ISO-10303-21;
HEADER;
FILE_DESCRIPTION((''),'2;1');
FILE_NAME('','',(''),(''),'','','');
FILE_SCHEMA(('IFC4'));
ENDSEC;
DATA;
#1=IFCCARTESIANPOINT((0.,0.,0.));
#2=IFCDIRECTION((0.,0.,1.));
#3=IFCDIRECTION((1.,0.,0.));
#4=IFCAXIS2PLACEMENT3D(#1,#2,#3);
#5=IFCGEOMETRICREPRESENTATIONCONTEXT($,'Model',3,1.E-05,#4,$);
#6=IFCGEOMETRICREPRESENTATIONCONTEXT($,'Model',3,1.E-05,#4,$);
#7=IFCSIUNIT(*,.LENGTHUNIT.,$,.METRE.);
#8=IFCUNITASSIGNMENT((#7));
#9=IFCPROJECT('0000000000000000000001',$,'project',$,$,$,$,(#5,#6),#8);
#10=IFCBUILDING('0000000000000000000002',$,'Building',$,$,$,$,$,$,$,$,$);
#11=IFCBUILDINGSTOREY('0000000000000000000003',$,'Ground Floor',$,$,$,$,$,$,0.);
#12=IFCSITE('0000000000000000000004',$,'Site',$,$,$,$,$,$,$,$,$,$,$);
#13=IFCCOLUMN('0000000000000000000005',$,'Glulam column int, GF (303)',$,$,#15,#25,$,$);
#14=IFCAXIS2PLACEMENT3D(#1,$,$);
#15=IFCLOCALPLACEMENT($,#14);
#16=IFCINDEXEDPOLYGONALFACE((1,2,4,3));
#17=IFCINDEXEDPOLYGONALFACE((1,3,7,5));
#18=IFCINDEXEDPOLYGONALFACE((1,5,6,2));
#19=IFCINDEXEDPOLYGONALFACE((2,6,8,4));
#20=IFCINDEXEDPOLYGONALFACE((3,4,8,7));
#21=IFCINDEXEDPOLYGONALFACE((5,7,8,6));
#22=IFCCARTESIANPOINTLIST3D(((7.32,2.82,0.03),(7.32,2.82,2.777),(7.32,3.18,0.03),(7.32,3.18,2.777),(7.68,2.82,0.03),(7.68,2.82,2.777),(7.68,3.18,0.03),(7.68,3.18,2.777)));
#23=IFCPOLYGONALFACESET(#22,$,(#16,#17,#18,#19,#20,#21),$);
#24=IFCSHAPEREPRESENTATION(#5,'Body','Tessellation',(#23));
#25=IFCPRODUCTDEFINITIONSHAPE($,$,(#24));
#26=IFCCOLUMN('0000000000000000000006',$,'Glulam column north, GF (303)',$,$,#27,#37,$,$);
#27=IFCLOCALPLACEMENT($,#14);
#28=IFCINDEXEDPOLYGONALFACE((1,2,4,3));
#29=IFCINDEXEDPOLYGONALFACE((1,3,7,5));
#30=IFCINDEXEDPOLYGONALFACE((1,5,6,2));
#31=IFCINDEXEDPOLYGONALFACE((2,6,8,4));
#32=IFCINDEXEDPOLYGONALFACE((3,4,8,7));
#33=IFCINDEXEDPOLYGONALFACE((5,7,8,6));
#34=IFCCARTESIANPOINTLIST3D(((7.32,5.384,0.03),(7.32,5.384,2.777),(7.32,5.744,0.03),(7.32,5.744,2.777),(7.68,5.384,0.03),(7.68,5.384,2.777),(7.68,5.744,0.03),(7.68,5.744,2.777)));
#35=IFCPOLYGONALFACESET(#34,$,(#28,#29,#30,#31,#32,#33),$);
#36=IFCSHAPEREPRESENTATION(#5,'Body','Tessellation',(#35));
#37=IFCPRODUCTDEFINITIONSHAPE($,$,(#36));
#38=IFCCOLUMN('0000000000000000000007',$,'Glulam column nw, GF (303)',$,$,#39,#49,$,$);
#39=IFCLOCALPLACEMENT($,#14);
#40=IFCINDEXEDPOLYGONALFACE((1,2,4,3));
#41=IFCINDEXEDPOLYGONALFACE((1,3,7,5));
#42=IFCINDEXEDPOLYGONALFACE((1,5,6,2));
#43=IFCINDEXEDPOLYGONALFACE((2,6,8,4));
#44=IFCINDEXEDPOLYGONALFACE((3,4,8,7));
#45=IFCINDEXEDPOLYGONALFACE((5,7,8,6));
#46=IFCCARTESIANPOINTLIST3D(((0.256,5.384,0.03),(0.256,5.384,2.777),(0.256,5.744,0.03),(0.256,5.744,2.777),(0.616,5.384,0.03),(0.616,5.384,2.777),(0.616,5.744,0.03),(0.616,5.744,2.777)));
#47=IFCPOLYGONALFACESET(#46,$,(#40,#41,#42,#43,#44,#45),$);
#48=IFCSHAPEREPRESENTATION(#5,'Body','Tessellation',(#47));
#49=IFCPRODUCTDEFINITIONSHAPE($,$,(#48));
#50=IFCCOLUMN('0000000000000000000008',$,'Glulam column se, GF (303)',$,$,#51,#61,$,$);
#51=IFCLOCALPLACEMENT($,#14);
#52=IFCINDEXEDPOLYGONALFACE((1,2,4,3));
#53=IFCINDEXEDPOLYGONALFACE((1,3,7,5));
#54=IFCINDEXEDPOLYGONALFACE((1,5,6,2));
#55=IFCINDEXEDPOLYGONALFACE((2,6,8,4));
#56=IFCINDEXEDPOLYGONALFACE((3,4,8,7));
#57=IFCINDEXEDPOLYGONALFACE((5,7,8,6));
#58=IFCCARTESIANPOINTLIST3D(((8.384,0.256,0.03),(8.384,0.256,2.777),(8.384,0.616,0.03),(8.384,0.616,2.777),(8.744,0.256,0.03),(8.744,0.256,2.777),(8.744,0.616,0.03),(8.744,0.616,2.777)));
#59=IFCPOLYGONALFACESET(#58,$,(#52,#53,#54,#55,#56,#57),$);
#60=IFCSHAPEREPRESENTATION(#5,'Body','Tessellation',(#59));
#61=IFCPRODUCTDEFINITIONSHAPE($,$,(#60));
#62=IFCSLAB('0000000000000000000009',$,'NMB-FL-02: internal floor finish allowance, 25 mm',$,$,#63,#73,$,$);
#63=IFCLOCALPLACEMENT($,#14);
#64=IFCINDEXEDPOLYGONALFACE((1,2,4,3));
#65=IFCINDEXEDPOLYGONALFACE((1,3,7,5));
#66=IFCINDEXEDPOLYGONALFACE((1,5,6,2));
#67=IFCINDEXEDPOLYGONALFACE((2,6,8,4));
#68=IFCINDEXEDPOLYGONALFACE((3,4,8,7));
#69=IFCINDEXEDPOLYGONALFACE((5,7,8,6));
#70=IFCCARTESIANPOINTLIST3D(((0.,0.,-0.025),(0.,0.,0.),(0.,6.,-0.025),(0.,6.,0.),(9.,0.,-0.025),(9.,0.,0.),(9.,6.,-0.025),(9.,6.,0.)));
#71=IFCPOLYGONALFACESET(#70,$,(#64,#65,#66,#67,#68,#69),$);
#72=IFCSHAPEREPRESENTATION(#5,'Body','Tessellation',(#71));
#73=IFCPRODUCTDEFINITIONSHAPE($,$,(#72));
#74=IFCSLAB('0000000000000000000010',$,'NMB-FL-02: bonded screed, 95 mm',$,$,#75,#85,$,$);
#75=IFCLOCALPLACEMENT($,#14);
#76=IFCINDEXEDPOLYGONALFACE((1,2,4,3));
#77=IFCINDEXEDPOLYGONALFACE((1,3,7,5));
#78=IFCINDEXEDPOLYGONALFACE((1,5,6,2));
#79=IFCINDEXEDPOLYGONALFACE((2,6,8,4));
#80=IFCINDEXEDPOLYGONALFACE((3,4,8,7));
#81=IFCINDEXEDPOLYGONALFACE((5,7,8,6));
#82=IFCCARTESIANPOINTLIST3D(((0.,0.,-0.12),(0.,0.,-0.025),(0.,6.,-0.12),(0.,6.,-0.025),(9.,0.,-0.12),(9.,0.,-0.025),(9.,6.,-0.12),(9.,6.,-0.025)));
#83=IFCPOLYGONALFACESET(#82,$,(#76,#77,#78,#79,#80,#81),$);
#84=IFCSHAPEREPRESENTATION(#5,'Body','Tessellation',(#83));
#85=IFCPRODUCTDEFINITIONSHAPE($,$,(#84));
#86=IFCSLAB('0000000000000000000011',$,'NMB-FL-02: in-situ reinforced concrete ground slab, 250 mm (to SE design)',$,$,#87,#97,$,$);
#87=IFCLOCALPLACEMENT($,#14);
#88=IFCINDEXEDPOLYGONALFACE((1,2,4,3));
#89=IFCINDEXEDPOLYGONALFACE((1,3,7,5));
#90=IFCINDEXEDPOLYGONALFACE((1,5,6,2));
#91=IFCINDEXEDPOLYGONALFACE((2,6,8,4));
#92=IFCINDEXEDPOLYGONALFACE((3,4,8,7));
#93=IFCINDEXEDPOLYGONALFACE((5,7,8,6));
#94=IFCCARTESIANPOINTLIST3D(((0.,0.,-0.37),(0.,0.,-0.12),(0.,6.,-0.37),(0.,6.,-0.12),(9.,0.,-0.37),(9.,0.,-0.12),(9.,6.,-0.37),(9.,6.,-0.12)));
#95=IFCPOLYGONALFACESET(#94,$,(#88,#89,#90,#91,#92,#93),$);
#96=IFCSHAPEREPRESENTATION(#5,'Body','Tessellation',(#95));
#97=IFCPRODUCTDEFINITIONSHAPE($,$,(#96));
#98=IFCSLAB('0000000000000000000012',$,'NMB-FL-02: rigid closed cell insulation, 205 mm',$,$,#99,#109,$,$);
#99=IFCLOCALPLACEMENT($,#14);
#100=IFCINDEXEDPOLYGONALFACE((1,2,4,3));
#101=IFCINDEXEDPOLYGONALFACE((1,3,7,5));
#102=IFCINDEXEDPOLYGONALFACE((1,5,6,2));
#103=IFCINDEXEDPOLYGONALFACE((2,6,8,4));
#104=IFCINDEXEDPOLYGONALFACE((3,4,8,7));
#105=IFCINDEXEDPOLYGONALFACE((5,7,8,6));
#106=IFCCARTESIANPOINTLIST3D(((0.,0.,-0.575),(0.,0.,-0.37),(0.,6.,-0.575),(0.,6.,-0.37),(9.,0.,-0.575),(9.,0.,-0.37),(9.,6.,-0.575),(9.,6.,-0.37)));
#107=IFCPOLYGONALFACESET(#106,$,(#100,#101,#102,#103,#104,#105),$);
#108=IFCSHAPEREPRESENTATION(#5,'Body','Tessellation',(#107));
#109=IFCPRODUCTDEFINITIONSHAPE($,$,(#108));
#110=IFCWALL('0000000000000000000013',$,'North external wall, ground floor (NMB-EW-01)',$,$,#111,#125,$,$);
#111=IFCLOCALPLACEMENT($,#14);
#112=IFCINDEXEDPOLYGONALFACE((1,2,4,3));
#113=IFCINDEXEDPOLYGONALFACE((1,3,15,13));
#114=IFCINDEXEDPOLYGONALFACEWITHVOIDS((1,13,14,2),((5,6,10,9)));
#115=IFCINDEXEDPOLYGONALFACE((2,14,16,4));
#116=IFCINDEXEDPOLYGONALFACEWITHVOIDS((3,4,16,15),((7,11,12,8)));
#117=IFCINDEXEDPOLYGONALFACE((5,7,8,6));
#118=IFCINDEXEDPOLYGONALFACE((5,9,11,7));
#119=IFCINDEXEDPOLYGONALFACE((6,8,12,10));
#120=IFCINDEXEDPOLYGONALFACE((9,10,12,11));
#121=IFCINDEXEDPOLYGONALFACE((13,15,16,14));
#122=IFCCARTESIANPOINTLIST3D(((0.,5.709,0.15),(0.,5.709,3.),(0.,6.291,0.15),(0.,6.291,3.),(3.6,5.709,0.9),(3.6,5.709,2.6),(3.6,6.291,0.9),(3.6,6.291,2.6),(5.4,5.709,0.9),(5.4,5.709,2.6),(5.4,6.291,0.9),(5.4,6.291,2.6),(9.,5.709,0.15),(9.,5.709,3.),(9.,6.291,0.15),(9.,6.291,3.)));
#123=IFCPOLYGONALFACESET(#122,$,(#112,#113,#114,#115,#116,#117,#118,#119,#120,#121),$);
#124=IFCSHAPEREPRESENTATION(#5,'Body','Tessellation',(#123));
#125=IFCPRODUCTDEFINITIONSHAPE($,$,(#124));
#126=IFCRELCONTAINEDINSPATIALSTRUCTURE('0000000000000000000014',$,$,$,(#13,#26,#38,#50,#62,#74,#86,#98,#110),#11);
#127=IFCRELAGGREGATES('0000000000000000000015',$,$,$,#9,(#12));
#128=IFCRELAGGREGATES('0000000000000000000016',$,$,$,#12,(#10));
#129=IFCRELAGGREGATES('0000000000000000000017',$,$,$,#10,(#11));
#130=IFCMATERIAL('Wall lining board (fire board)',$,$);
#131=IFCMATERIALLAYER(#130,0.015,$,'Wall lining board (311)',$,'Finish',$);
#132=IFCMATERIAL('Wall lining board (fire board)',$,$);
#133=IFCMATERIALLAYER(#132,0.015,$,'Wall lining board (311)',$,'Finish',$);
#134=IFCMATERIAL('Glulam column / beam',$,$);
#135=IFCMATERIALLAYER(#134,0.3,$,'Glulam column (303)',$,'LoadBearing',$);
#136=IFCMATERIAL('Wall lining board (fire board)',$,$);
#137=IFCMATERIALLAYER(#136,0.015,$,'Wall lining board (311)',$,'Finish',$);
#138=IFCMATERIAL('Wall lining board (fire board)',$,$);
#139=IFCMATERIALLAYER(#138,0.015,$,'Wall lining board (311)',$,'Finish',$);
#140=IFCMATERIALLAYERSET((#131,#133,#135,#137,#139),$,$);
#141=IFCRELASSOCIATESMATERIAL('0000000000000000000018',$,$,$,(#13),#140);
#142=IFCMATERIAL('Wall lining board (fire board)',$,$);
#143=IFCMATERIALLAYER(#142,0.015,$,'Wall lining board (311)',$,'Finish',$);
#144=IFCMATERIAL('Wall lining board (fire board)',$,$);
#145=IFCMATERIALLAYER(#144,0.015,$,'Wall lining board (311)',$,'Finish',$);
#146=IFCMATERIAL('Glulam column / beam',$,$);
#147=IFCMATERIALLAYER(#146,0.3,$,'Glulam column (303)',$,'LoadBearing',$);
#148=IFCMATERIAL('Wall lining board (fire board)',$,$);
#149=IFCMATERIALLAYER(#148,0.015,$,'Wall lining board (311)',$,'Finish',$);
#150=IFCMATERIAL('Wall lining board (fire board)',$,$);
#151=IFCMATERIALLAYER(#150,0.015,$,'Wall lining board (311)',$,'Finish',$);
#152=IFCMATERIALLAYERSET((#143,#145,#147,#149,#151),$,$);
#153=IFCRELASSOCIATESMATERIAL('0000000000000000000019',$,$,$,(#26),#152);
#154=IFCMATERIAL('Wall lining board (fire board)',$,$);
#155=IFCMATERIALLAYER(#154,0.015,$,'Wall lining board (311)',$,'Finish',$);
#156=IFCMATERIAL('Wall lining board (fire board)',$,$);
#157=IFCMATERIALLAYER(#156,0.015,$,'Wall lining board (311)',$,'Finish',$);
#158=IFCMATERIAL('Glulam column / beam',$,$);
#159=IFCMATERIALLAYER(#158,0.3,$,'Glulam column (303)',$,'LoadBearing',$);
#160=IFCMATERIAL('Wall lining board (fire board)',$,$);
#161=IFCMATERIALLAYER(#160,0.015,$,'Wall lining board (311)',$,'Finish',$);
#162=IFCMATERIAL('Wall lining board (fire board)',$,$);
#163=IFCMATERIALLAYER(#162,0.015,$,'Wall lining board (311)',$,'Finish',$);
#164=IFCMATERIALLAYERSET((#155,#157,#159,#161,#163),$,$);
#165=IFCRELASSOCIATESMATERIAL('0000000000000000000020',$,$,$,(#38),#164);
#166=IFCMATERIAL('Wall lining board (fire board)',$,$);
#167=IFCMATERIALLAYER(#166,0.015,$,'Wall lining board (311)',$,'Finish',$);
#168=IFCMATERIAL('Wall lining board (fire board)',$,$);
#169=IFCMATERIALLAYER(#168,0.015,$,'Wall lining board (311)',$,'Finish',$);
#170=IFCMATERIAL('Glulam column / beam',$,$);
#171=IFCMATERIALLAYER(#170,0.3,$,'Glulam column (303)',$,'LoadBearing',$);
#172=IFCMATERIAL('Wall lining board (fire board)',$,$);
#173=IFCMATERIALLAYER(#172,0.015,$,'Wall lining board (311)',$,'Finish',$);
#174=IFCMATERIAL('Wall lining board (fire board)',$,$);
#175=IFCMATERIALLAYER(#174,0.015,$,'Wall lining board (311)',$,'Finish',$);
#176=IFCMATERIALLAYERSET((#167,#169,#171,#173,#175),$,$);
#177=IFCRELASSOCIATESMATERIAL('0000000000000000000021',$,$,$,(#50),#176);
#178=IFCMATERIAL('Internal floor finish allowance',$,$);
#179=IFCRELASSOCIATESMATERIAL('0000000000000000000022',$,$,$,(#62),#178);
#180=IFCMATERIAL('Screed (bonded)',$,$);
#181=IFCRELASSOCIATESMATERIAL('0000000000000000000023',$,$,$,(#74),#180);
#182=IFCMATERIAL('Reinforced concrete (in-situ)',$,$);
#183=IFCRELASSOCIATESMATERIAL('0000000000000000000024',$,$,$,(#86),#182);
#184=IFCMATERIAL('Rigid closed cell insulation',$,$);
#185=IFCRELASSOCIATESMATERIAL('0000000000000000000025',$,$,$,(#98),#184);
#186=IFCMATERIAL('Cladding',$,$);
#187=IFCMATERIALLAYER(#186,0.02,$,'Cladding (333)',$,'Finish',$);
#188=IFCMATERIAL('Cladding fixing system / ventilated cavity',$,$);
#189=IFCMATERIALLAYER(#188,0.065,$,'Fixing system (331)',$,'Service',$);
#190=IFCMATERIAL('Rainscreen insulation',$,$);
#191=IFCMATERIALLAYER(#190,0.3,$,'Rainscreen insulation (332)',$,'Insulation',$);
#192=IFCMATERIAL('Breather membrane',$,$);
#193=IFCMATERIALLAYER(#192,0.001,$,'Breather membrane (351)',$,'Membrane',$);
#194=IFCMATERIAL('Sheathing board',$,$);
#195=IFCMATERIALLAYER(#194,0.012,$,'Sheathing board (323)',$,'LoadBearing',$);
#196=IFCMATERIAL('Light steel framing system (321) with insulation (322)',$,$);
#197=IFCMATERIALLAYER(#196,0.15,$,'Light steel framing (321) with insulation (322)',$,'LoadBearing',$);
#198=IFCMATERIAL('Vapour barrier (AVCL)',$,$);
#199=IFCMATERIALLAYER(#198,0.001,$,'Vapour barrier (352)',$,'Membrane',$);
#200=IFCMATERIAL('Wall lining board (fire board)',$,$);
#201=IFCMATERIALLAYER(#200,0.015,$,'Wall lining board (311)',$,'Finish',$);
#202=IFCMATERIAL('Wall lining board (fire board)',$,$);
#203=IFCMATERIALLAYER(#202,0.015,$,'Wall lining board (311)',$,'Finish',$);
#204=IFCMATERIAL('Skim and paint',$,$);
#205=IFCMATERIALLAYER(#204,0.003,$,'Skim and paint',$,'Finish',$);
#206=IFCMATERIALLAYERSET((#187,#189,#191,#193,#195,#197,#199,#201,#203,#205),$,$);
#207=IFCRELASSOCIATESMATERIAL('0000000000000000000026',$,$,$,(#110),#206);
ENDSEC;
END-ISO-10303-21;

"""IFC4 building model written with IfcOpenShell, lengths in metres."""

from ifc_helpers import new_model, si_unit, frame, frame_2d, origin, origin_with_axes, origin_2d, place, context, project, spatial, polyline, rectangle, outline, extrude, material, layer, layer_set, layer_usage, element, save


model = new_model("IFC4")

# Units and contexts
model_context_1 = context("Model", 3, precision=1e-05, world=origin_with_axes())
model_context_2 = context("Model", 3, precision=1e-05, world=origin_with_axes())
ifc_project = project(units=[si_unit("LENGTHUNIT", "METRE")], contexts=[model_context_1, model_context_2])

# Site, building, storey
site = spatial("IfcSite", under=ifc_project, Name="Site")
building = spatial("IfcBuilding", under=site, Name="Building")
storey = spatial("IfcBuildingStorey", under=building, Name="Ground Floor", Elevation=0.0)

# Columns
ifc_material_1 = material(Name="Wall lining board (fire board)")
ifc_layer_1 = layer(ifc_material_1, 0.015, Name="Wall lining board (311)", Category="Finish")
ifc_material_2 = material(Name="Wall lining board (fire board)")
ifc_layer_2 = layer(ifc_material_2, 0.015, Name="Wall lining board (311)", Category="Finish")
ifc_material_3 = material(Name="Glulam column / beam")
ifc_layer_3 = layer(ifc_material_3, 0.3, Name="Glulam column (303)", Category="LoadBearing")
ifc_material_4 = material(Name="Wall lining board (fire board)")
ifc_layer_4 = layer(ifc_material_4, 0.015, Name="Wall lining board (311)", Category="Finish")
ifc_material_5 = material(Name="Wall lining board (fire board)")
ifc_layer_5 = layer(ifc_material_5, 0.015, Name="Wall lining board (311)", Category="Finish")
ifc_layer_set_1 = layer_set([ifc_layer_1, ifc_layer_2, ifc_layer_3, ifc_layer_4, ifc_layer_5])
ifc_layer_usage_1 = layer_usage(ifc_layer_set_1, "AXIS2", "NEGATIVE", 0.18)
column_1_placement = place(None, frame((7.32, 3.0, 0.03), z_axis=(0.0, 0.0, 1.0), x_axis=(1.0, 0.0, 0.0)))
element("IfcColumn", 1, at=column_1_placement, inside=storey, material=ifc_layer_usage_1, Name="Glulam column int, GF (303)", context=model_context_1, shape_type="SweptSolid", body=[
    extrude(rectangle(XDim=0.36, YDim=2.747, at=frame_2d((0.0, 1.3735))), frame((0.0, 0.0, 0.0), z_axis=(1.0, 0.0, 0.0), x_axis=(0.0, 1.0, 0.0)), (0.0, 0.0, 1.0), 0.36),
])
ifc_material_6 = material(Name="Wall lining board (fire board)")
ifc_layer_6 = layer(ifc_material_6, 0.015, Name="Wall lining board (311)", Category="Finish")
ifc_material_7 = material(Name="Wall lining board (fire board)")
ifc_layer_7 = layer(ifc_material_7, 0.015, Name="Wall lining board (311)", Category="Finish")
ifc_material_8 = material(Name="Glulam column / beam")
ifc_layer_8 = layer(ifc_material_8, 0.3, Name="Glulam column (303)", Category="LoadBearing")
ifc_material_9 = material(Name="Wall lining board (fire board)")
ifc_layer_9 = layer(ifc_material_9, 0.015, Name="Wall lining board (311)", Category="Finish")
ifc_material_10 = material(Name="Wall lining board (fire board)")
ifc_layer_10 = layer(ifc_material_10, 0.015, Name="Wall lining board (311)", Category="Finish")
ifc_layer_set_2 = layer_set([ifc_layer_6, ifc_layer_7, ifc_layer_8, ifc_layer_9, ifc_layer_10])
ifc_layer_usage_2 = layer_usage(ifc_layer_set_2, "AXIS2", "NEGATIVE", 0.18)
column_2_placement = place(None, frame((7.32, 5.564, 0.03), z_axis=(0.0, 0.0, 1.0), x_axis=(1.0, 0.0, 0.0)))
element("IfcColumn", 2, at=column_2_placement, inside=storey, material=ifc_layer_usage_2, Name="Glulam column north, GF (303)", context=model_context_1, shape_type="SweptSolid", body=[
    extrude(rectangle(XDim=0.36, YDim=2.747, at=frame_2d((0.0, 1.3735))), frame((0.0, 0.0, 0.0), z_axis=(1.0, 0.0, 0.0), x_axis=(0.0, 1.0, 0.0)), (0.0, 0.0, 1.0), 0.36),
])
ifc_material_11 = material(Name="Wall lining board (fire board)")
ifc_layer_11 = layer(ifc_material_11, 0.015, Name="Wall lining board (311)", Category="Finish")
ifc_material_12 = material(Name="Wall lining board (fire board)")
ifc_layer_12 = layer(ifc_material_12, 0.015, Name="Wall lining board (311)", Category="Finish")
ifc_material_13 = material(Name="Glulam column / beam")
ifc_layer_13 = layer(ifc_material_13, 0.3, Name="Glulam column (303)", Category="LoadBearing")
ifc_material_14 = material(Name="Wall lining board (fire board)")
ifc_layer_14 = layer(ifc_material_14, 0.015, Name="Wall lining board (311)", Category="Finish")
ifc_material_15 = material(Name="Wall lining board (fire board)")
ifc_layer_15 = layer(ifc_material_15, 0.015, Name="Wall lining board (311)", Category="Finish")
ifc_layer_set_3 = layer_set([ifc_layer_11, ifc_layer_12, ifc_layer_13, ifc_layer_14, ifc_layer_15])
ifc_layer_usage_3 = layer_usage(ifc_layer_set_3, "AXIS2", "NEGATIVE", 0.18)
column_3_placement = place(None, frame((0.256, 5.564, 0.03), z_axis=(0.0, 0.0, 1.0), x_axis=(1.0, 0.0, 0.0)))
element("IfcColumn", 3, at=column_3_placement, inside=storey, material=ifc_layer_usage_3, Name="Glulam column nw, GF (303)", context=model_context_1, shape_type="SweptSolid", body=[
    extrude(rectangle(XDim=0.36, YDim=2.747, at=frame_2d((0.0, 1.3735))), frame((0.0, 0.0, 0.0), z_axis=(1.0, 0.0, 0.0), x_axis=(0.0, 1.0, 0.0)), (0.0, 0.0, 1.0), 0.36),
])
ifc_material_16 = material(Name="Wall lining board (fire board)")
ifc_layer_16 = layer(ifc_material_16, 0.015, Name="Wall lining board (311)", Category="Finish")
ifc_material_17 = material(Name="Wall lining board (fire board)")
ifc_layer_17 = layer(ifc_material_17, 0.015, Name="Wall lining board (311)", Category="Finish")
ifc_material_18 = material(Name="Glulam column / beam")
ifc_layer_18 = layer(ifc_material_18, 0.3, Name="Glulam column (303)", Category="LoadBearing")
ifc_material_19 = material(Name="Wall lining board (fire board)")
ifc_layer_19 = layer(ifc_material_19, 0.015, Name="Wall lining board (311)", Category="Finish")
ifc_material_20 = material(Name="Wall lining board (fire board)")
ifc_layer_20 = layer(ifc_material_20, 0.015, Name="Wall lining board (311)", Category="Finish")
ifc_layer_set_4 = layer_set([ifc_layer_16, ifc_layer_17, ifc_layer_18, ifc_layer_19, ifc_layer_20])
ifc_layer_usage_4 = layer_usage(ifc_layer_set_4, "AXIS2", "NEGATIVE", 0.18)
column_4_placement = place(None, frame((8.384, 0.436, 0.03), z_axis=(0.0, 0.0, 1.0), x_axis=(1.0, 0.0, 0.0)))
element("IfcColumn", 4, at=column_4_placement, inside=storey, material=ifc_layer_usage_4, Name="Glulam column se, GF (303)", context=model_context_1, shape_type="SweptSolid", body=[
    extrude(rectangle(XDim=0.36, YDim=2.747, at=frame_2d((0.0, 1.3735))), frame((0.0, 0.0, 0.0), z_axis=(1.0, 0.0, 0.0), x_axis=(0.0, 1.0, 0.0)), (0.0, 0.0, 1.0), 0.36),
])

# Slabs
ifc_material_21 = material(Name="Internal floor finish allowance")
slab_1_placement = place(None, origin_with_axes())
element("IfcSlab", 5, at=slab_1_placement, inside=storey, material=ifc_material_21, Name="NMB-FL-02: internal floor finish allowance, 25 mm", context=model_context_1, shape_type="SweptSolid", body=[
    extrude(outline(polyline([(0.0, 0.0), (0.0, 6.0), (9.0, 6.0), (9.0, 0.0), (0.0, 0.0)])), origin(), (0.0, 0.0, -1.0), 0.025),
])
ifc_material_22 = material(Name="Screed (bonded)")
slab_2_placement = place(None, frame((0.0, 0.0, -0.025), z_axis=(0.0, 0.0, 1.0), x_axis=(1.0, 0.0, 0.0)))
element("IfcSlab", 6, at=slab_2_placement, inside=storey, material=ifc_material_22, Name="NMB-FL-02: bonded screed, 95 mm", context=model_context_1, shape_type="SweptSolid", body=[
    extrude(outline(polyline([(0.0, 0.0), (0.0, 6.0), (9.0, 6.0), (9.0, 0.0), (0.0, 0.0)])), origin(), (0.0, 0.0, -1.0), 0.095),
])
ifc_material_23 = material(Name="Reinforced concrete (in-situ)")
slab_3_placement = place(None, frame((0.0, 0.0, -0.12), z_axis=(0.0, 0.0, 1.0), x_axis=(1.0, 0.0, 0.0)))
element("IfcSlab", 7, at=slab_3_placement, inside=storey, material=ifc_material_23, Name="NMB-FL-02: in-situ reinforced concrete ground slab, 250 mm (to SE design)", context=model_context_1, shape_type="SweptSolid", body=[
    extrude(outline(polyline([(0.0, 0.0), (0.0, 6.0), (9.0, 6.0), (9.0, 0.0), (0.0, 0.0)])), origin(), (0.0, 0.0, -1.0), 0.25),
])
ifc_material_24 = material(Name="Rigid closed cell insulation")
slab_4_placement = place(None, frame((0.0, 0.0, -0.37), z_axis=(0.0, 0.0, 1.0), x_axis=(1.0, 0.0, 0.0)))
element("IfcSlab", 8, at=slab_4_placement, inside=storey, material=ifc_material_24, Name="NMB-FL-02: rigid closed cell insulation, 205 mm", context=model_context_1, shape_type="SweptSolid", body=[
    extrude(outline(polyline([(0.0, 0.0), (0.0, 6.0), (9.0, 6.0), (9.0, 0.0), (0.0, 0.0)])), origin(), (0.0, 0.0, -1.0), 0.205),
])

# Wall, opening
ifc_material_25 = material(Name="Cladding")
ifc_layer_21 = layer(ifc_material_25, 0.02, Name="Cladding (333)", Category="Finish")
ifc_material_26 = material(Name="Cladding fixing system / ventilated cavity")
ifc_layer_22 = layer(ifc_material_26, 0.065, Name="Fixing system (331)", Category="Service")
ifc_material_27 = material(Name="Rainscreen insulation")
ifc_layer_23 = layer(ifc_material_27, 0.3, Name="Rainscreen insulation (332)", Category="Insulation")
ifc_material_28 = material(Name="Breather membrane")
ifc_layer_24 = layer(ifc_material_28, 0.001, Name="Breather membrane (351)", Category="Membrane")
ifc_material_29 = material(Name="Sheathing board")
ifc_layer_25 = layer(ifc_material_29, 0.012, Name="Sheathing board (323)", Category="LoadBearing")
ifc_material_30 = material(Name="Light steel framing system (321) with insulation (322)")
ifc_layer_26 = layer(ifc_material_30, 0.15, Name="Light steel framing (321) with insulation (322)", Category="LoadBearing")
ifc_material_31 = material(Name="Vapour barrier (AVCL)")
ifc_layer_27 = layer(ifc_material_31, 0.001, Name="Vapour barrier (352)", Category="Membrane")
ifc_material_32 = material(Name="Wall lining board (fire board)")
ifc_layer_28 = layer(ifc_material_32, 0.015, Name="Wall lining board (311)", Category="Finish")
ifc_material_33 = material(Name="Wall lining board (fire board)")
ifc_layer_29 = layer(ifc_material_33, 0.015, Name="Wall lining board (311)", Category="Finish")
ifc_material_34 = material(Name="Skim and paint")
ifc_layer_30 = layer(ifc_material_34, 0.003, Name="Skim and paint", Category="Finish")
ifc_layer_set_5 = layer_set([ifc_layer_21, ifc_layer_22, ifc_layer_23, ifc_layer_24, ifc_layer_25, ifc_layer_26, ifc_layer_27, ifc_layer_28, ifc_layer_29, ifc_layer_30])
ifc_layer_usage_5 = layer_usage(ifc_layer_set_5, "AXIS2", "NEGATIVE", 0.291)
wall_1_placement = place(None, frame((0.0, 6.0, 0.15), z_axis=(0.0, 0.0, 1.0), x_axis=(1.0, 0.0, 0.0)))
wall_1 = element("IfcWall", 9, at=wall_1_placement, inside=storey, material=ifc_layer_usage_5, Name="North external wall, ground floor (NMB-EW-01)", context=model_context_1, shape_type="SweptSolid", body=[
    extrude(rectangle(XDim=0.582, YDim=2.85, at=frame_2d((0.0, 1.425))), frame((0.0, 0.0, 0.0), z_axis=(1.0, 0.0, 0.0), x_axis=(0.0, 1.0, 0.0)), (0.0, 0.0, 1.0), 9.0),
])
opening_1_placement = place(wall_1_placement, frame((4.5, 0.0, 0.75), z_axis=(0.0, 0.0, 1.0), x_axis=(1.0, 0.0, 0.0)))
element("IfcOpeningElement", 10, at=opening_1_placement, cuts=wall_1, context=model_context_1, shape_type="SweptSolid", body=[
    extrude(rectangle(XDim=1.8, YDim=0.582, at=origin_2d()), origin(), (0.0, 0.0, 1.0), 1.7),
])

save(model, "model.ifc")
